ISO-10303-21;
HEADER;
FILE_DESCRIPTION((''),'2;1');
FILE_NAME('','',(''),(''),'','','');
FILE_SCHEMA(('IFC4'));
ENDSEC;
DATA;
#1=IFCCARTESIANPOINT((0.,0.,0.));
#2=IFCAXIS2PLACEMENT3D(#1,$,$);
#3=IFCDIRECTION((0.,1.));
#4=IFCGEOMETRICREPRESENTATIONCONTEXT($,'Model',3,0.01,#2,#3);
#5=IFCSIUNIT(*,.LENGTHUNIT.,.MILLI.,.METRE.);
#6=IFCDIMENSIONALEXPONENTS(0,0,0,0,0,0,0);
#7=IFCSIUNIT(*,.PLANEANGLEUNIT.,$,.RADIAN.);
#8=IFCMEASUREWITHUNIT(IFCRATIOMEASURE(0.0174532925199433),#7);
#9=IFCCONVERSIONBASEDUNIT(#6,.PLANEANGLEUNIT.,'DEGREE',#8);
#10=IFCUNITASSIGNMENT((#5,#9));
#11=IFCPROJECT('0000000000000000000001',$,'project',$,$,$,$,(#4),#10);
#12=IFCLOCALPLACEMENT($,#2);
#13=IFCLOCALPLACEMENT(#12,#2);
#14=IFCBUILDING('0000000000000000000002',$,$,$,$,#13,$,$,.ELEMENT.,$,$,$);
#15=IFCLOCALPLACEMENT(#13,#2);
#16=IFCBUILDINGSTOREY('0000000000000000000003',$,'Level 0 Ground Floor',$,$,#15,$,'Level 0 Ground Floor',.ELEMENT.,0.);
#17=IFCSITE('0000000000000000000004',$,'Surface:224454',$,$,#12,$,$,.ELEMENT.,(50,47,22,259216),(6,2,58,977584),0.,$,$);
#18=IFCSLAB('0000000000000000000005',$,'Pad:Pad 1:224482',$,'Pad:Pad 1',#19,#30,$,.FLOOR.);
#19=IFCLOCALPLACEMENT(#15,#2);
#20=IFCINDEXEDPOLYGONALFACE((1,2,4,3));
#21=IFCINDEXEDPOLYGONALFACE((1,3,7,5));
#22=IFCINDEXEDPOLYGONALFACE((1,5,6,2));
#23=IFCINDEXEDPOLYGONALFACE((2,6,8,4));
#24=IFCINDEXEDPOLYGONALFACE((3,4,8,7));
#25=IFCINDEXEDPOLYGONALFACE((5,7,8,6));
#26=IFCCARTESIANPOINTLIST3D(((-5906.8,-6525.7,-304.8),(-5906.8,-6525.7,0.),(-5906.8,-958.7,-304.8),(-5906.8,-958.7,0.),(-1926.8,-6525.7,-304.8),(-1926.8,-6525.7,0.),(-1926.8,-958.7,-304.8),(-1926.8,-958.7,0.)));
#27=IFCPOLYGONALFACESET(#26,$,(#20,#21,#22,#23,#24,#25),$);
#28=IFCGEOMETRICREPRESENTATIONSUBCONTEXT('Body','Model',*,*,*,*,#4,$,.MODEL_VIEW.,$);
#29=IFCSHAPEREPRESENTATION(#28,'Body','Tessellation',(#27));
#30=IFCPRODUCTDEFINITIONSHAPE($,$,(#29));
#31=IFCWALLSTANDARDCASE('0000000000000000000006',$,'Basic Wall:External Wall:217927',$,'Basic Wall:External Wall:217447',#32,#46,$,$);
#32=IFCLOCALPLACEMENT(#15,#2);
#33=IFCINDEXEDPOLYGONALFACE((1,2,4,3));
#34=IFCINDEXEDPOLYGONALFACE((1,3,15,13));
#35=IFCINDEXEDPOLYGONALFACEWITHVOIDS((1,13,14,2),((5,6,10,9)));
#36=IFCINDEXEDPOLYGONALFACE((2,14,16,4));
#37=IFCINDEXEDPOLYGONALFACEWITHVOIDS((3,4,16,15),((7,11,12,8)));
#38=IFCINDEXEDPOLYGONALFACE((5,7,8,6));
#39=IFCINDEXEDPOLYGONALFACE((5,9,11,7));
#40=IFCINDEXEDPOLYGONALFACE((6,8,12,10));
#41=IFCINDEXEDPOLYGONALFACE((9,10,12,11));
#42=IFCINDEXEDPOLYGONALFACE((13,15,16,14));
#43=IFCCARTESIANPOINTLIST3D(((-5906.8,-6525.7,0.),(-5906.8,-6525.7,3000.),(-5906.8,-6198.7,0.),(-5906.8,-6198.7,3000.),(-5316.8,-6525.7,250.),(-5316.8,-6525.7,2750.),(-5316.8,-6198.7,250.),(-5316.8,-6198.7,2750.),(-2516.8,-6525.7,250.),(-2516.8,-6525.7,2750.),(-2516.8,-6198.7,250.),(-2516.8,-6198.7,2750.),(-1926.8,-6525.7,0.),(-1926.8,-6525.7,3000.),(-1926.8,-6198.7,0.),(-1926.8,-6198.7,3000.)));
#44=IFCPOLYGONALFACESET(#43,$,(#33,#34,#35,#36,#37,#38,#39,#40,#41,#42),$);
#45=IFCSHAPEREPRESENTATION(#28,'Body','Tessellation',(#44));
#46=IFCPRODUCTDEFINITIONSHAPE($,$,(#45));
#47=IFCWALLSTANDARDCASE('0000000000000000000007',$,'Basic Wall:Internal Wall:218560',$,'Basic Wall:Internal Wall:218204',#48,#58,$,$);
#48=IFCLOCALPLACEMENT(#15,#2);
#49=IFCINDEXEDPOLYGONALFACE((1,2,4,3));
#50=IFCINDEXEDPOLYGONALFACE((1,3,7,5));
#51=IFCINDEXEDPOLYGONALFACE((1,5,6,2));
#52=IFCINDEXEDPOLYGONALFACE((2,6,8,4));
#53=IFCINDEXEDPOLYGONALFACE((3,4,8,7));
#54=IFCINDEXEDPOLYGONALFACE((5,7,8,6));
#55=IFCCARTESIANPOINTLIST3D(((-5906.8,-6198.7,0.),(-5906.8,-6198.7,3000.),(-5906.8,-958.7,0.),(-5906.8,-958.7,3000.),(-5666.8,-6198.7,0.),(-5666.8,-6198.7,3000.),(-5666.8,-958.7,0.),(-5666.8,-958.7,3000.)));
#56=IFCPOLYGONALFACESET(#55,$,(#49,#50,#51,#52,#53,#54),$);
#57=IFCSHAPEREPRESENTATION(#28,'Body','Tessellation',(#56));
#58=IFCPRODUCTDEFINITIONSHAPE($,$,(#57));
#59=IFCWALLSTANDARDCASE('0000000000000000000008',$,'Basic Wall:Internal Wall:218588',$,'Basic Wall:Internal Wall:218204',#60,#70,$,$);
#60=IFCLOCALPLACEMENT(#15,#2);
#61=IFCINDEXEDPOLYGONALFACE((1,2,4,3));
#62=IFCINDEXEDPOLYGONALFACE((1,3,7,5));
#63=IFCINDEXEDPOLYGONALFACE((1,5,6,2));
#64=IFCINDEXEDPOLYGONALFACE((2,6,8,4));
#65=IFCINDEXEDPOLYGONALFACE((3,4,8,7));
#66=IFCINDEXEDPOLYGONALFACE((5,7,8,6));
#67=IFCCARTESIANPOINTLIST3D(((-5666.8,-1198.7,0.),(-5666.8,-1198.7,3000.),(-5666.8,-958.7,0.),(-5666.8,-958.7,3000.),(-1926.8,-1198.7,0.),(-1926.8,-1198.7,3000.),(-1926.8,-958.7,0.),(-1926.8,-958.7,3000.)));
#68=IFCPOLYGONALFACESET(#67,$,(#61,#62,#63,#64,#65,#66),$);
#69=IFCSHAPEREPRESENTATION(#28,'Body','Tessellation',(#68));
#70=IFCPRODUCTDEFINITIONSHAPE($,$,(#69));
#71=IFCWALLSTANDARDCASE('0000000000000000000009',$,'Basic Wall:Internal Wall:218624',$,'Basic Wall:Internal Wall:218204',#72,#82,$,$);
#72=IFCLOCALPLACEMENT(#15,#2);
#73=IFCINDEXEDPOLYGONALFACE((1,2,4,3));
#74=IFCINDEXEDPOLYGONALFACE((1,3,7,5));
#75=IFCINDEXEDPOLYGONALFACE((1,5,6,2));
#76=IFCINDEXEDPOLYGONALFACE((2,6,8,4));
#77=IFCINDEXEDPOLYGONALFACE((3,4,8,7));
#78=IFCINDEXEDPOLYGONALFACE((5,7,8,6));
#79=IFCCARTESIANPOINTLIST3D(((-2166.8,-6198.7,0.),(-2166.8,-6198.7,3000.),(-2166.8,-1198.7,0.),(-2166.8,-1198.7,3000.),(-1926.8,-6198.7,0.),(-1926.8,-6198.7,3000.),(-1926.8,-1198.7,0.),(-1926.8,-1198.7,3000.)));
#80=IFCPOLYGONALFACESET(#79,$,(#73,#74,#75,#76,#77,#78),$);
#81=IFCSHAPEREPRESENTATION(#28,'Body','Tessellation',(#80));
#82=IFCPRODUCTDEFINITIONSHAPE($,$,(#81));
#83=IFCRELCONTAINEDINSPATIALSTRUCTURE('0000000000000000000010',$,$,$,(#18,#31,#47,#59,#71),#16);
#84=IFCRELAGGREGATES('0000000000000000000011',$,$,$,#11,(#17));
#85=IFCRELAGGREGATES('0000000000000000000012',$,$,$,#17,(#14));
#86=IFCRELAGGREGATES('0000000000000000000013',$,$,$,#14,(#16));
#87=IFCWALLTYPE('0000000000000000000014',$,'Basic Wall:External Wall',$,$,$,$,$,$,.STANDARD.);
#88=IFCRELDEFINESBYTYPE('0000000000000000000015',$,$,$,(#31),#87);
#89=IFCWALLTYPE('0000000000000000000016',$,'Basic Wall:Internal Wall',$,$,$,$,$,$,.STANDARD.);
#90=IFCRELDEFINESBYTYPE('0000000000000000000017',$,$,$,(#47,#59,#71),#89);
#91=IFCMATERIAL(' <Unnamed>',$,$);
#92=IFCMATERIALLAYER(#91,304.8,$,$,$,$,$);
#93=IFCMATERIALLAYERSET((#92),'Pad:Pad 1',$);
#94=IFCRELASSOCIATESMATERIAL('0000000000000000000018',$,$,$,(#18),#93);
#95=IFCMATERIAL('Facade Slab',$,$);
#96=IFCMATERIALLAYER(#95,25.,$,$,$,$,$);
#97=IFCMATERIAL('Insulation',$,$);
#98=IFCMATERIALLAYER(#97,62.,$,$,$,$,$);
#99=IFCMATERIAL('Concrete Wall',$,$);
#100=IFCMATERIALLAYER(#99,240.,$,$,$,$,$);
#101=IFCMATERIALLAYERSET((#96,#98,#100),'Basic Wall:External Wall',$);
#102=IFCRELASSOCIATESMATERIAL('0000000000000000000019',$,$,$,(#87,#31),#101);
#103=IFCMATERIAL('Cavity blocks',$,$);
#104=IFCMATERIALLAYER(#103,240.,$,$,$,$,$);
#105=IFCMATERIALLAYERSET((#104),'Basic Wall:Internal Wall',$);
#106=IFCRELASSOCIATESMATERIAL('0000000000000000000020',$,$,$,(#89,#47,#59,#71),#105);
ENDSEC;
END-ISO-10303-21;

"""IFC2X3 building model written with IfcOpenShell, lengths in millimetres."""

from ifc_helpers import new_model, entity, si_unit, converted_unit, direction, frame, frame_2d, origin, place, context, subcontext, project, spatial, polyline, rectangle, extrude, clip, bounded_halfspace, material, layer, layer_set, layer_usage, type_object, element, save


model = new_model("IFC2X3")

# Units and contexts
model_context = context("Model", 3, precision=0.01, world=origin(), true_north=direction((0.0, 1.0)))
body_context = subcontext(model_context, "Body", "Model", "MODEL_VIEW")
ifc_project = project(units=[si_unit("LENGTHUNIT", "METRE", prefix="MILLI"), converted_unit("PLANEANGLEUNIT", "DEGREE", entity("IfcRatioMeasure", 0.0174532925199433), si_unit("PLANEANGLEUNIT", "RADIAN"), dimensions=[0, 0, 0, 0, 0, 0, 0])], contexts=[model_context])

# Site, building, storey
site_placement = place(None, origin())
site = spatial("IfcSite", under=ifc_project, at=site_placement, Name="Surface:224454", CompositionType="ELEMENT", RefLatitude=(50, 47, 22, 259216), RefLongitude=(6, 2, 58, 977584), RefElevation=0.0)
building_placement = place(site_placement, origin())
building = spatial("IfcBuilding", under=site, at=building_placement, CompositionType="ELEMENT")
storey_placement = place(building_placement, origin())
storey = spatial("IfcBuildingStorey", under=building, at=storey_placement, Name="Level 0 Ground Floor", LongName="Level 0 Ground Floor", CompositionType="ELEMENT", Elevation=0.0)

# Slab
ifc_material_1 = material(Name=" <Unnamed>")
ifc_layer_1 = layer(ifc_material_1, 304.8)
ifc_layer_set_1 = layer_set([ifc_layer_1], Name="Pad:Pad 1")
ifc_layer_usage_1 = layer_usage(ifc_layer_set_1, "AXIS3", "NEGATIVE", 0.0)
slab_placement = place(storey_placement, frame((-5906.8, -6525.7, -304.8)))
element("IfcSlab", 1, at=slab_placement, inside=storey, material=ifc_layer_usage_1, Name="Pad:Pad 1:224482", ObjectType="Pad:Pad 1", PredefinedType="FLOOR", context=body_context, shape_type="SweptSolid", body=[
    extrude(rectangle(XDim=5567.0, YDim=3980.0, at=frame_2d((0.0, 0.0), x_axis=(0.0, -1.0))), frame((1990.0, 2783.5, 304.8), z_axis=(0.0, 0.0, -1.0), x_axis=(-1.0, 0.0, 0.0)), (0.0, 0.0, 1.0), 304.8),
])

# Wall, opening
ifc_material_2 = material(Name="Facade Slab")
ifc_layer_2 = layer(ifc_material_2, 25.0)
ifc_material_3 = material(Name="Insulation")
ifc_layer_3 = layer(ifc_material_3, 62.0)
ifc_material_4 = material(Name="Concrete Wall")
ifc_layer_4 = layer(ifc_material_4, 240.0)
ifc_layer_set_2 = layer_set([ifc_layer_2, ifc_layer_3, ifc_layer_4], Name="Basic Wall:External Wall")
ifc_layer_usage_2 = layer_usage(ifc_layer_set_2, "AXIS2", "POSITIVE", -163.5)
wall_type_1 = type_object("IfcWallType", Name="Basic Wall:External Wall", PredefinedType="STANDARD", material=ifc_layer_set_2)
wall_1_placement = place(storey_placement, frame((-5906.8, -6362.2, 0.0)))
wall_1 = element("IfcWallStandardCase", 2, at=wall_1_placement, inside=storey, type_object=wall_type_1, material=ifc_layer_usage_2, Name="Basic Wall:External Wall:217927", ObjectType="Basic Wall:External Wall:217447", context=body_context, shape_type="Clipping", body=[
    clip(extrude(rectangle(XDim=3980.0, YDim=327.0, at=frame_2d((1990.0, 0.0), x_axis=(-1.0, 0.0))), origin(), (0.0, 0.0, 1.0), 3000.0), bounded_halfspace(frame((0.0, -163.5, 3000.0), z_axis=(0.0, 0.0, -1.0), x_axis=(0.0, -1.0, 0.0)), True, frame((0.0, -163.5, 3000.0)), polyline([(0.0, 0.0), (3980.0, 0.0), (3980.0, 327.0), (3740.0, 327.0), (240.0, 327.0), (0.0, 327.0), (0.0, 0.0)]))),
])
opening_placement = place(wall_1_placement, frame((590.0, -163.5, 250.0)))
element("IfcOpeningElement", 3, at=opening_placement, cuts=wall_1, ObjectType="Opening", context=body_context, shape_type="SweptSolid", body=[
    extrude(rectangle(XDim=2500.0, YDim=2800.0, at=frame_2d((1250.0, 1400.0), x_axis=(1.0, 0.0))), frame((0.0, 0.0, 0.0), z_axis=(0.0, 1.0, 0.0), x_axis=(0.0, 0.0, 1.0)), (0.0, 0.0, 1.0), 327.0),
])

# Walls
ifc_material_5 = material(Name="Cavity blocks")
ifc_layer_5 = layer(ifc_material_5, 240.0)
ifc_layer_set_3 = layer_set([ifc_layer_5], Name="Basic Wall:Internal Wall")
ifc_layer_usage_3 = layer_usage(ifc_layer_set_3, "AXIS2", "NEGATIVE", 120.0)
wall_type_2 = type_object("IfcWallType", Name="Basic Wall:Internal Wall", PredefinedType="STANDARD", material=ifc_layer_set_3)
wall_2_placement = place(storey_placement, frame((-5786.8, -6198.7, 0.0), z_axis=(0.0, 0.0, 1.0), x_axis=(0.0, 1.0, 0.0)))
element("IfcWallStandardCase", 4, at=wall_2_placement, inside=storey, type_object=wall_type_2, material=ifc_layer_usage_3, Name="Basic Wall:Internal Wall:218560", ObjectType="Basic Wall:Internal Wall:218204", context=body_context, shape_type="Clipping", body=[
    clip(extrude(rectangle(XDim=5240.0, YDim=240.0, at=frame_2d((2620.0, 0.0), x_axis=(-1.0, 0.0))), origin(), (0.0, 0.0, 1.0), 3000.0), bounded_halfspace(frame((0.0, -120.0, 3000.0), z_axis=(0.0, 0.0, -1.0), x_axis=(-1.0, 0.0, 0.0)), True, frame((0.0, -120.0, 3000.0)), polyline([(0.0, 0.0), (5000.0, 0.0), (5240.0, 0.0), (5240.0, 240.0), (0.0, 240.0), (0.0, 0.0)]))),
])
ifc_layer_usage_4 = layer_usage(ifc_layer_set_3, "AXIS2", "NEGATIVE", 120.0)
wall_3_placement = place(storey_placement, frame((-5666.8, -1078.7, 0.0)))
element("IfcWallStandardCase", 5, at=wall_3_placement, inside=storey, type_object=wall_type_2, material=ifc_layer_usage_4, Name="Basic Wall:Internal Wall:218588", ObjectType="Basic Wall:Internal Wall:218204", context=body_context, shape_type="Clipping", body=[
    clip(extrude(rectangle(XDim=3740.0, YDim=240.0, at=frame_2d((1870.0, 0.0), x_axis=(-1.0, 0.0))), origin(), (0.0, 0.0, 1.0), 3000.0), bounded_halfspace(frame((0.0, -120.0, 3000.0), z_axis=(0.0, 0.0, -1.0), x_axis=(0.0, -1.0, 0.0)), True, frame((0.0, -120.0, 3000.0)), polyline([(0.0, 0.0), (3500.0, 0.0), (3740.0, 0.0), (3740.0, 240.0), (0.0, 240.0), (0.0, 0.0)]))),
])
ifc_layer_usage_5 = layer_usage(ifc_layer_set_3, "AXIS2", "NEGATIVE", 120.0)
wall_4_placement = place(storey_placement, frame((-2046.8, -1198.7, 0.0), z_axis=(0.0, 0.0, 1.0), x_axis=(0.0, -1.0, 0.0)))
element("IfcWallStandardCase", 6, at=wall_4_placement, inside=storey, type_object=wall_type_2, material=ifc_layer_usage_5, Name="Basic Wall:Internal Wall:218624", ObjectType="Basic Wall:Internal Wall:218204", context=body_context, shape_type="Clipping", body=[
    clip(extrude(rectangle(XDim=5000.0, YDim=240.0, at=frame_2d((2500.0, 0.0), x_axis=(-1.0, 0.0))), origin(), (0.0, 0.0, 1.0), 3000.0), bounded_halfspace(frame((0.0, -120.0, 3000.0), z_axis=(0.0, 0.0, -1.0), x_axis=(1.0, 0.0, 0.0)), True, frame((0.0, -120.0, 3000.0)), polyline([(0.0, 0.0), (5000.0, 0.0), (5000.0, 240.0), (0.0, 240.0), (0.0, 0.0)]))),
])

save(model, "model.ifc")
